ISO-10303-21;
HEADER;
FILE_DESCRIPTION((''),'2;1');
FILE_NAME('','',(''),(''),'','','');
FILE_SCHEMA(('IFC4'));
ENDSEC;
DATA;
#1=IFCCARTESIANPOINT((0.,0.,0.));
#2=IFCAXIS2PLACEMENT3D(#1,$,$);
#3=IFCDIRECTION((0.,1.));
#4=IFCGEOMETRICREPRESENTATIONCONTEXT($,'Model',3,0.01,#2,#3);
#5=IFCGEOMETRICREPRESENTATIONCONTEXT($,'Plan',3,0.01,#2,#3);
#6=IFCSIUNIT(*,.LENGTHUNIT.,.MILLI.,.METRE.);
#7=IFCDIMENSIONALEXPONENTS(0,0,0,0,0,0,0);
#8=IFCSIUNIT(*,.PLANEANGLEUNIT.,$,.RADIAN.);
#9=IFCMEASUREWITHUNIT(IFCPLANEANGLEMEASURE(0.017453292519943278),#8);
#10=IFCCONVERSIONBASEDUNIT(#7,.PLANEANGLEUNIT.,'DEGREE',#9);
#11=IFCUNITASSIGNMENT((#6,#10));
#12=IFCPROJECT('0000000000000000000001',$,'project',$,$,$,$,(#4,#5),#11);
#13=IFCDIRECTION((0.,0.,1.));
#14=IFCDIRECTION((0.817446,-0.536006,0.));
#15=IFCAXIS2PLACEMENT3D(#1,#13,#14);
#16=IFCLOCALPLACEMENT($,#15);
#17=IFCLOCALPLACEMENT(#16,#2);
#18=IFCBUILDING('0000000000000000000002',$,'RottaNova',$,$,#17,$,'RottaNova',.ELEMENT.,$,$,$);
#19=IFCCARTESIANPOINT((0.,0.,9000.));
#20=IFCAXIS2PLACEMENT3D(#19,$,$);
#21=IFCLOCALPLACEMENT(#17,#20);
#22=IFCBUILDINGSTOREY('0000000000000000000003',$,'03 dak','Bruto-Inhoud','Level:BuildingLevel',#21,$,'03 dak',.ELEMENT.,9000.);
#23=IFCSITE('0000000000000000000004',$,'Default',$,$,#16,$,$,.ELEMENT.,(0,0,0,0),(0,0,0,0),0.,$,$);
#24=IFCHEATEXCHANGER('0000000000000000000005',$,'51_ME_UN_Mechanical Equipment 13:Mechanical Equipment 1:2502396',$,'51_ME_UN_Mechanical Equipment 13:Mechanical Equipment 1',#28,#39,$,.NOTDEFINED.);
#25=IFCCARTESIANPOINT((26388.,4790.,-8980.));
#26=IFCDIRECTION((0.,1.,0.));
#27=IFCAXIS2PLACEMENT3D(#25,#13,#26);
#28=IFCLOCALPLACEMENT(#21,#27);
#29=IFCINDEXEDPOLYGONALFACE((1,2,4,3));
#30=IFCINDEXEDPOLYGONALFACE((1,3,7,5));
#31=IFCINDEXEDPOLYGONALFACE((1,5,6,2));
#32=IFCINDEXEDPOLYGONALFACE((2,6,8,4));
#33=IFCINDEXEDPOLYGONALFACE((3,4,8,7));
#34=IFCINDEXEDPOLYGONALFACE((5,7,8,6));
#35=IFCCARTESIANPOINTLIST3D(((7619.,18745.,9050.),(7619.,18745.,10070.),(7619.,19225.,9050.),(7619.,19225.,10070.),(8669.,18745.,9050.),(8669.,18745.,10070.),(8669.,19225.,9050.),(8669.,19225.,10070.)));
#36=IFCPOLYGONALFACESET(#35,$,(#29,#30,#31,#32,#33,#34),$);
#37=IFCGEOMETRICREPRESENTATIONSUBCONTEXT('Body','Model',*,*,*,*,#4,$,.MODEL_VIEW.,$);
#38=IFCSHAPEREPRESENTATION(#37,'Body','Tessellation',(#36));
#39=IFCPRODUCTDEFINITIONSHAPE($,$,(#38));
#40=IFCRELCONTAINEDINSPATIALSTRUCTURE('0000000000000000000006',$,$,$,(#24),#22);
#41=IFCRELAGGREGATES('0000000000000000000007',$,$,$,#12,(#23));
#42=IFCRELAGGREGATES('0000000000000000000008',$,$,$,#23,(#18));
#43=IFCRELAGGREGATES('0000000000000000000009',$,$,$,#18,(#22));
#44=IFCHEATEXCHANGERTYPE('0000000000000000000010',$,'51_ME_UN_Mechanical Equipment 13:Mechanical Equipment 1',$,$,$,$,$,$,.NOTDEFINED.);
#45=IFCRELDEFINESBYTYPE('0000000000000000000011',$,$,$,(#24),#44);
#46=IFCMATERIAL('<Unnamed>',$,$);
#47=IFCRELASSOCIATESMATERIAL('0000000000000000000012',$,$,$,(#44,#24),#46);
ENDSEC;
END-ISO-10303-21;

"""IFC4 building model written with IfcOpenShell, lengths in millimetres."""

from ifc_helpers import new_model, entity, si_unit, converted_unit, direction, frame, origin, place, context, subcontext, project, spatial, indexed_curve, outline, extrude, source, transform, mapped, material, type_object, type_shapes, element, save


model = new_model("IFC4")

# Units and contexts
model_context = context("Model", 3, precision=0.01, world=origin(), true_north=direction((0.0, 1.0)))
plan_context = context("Plan", 3, precision=0.01, world=origin(), true_north=direction((0.0, 1.0)))
body_context = subcontext(model_context, "Body", "Model", "MODEL_VIEW")
ifc_project = project(units=[si_unit("LENGTHUNIT", "METRE", prefix="MILLI"), converted_unit("PLANEANGLEUNIT", "DEGREE", entity("IfcPlaneAngleMeasure", 0.017453292519943278), si_unit("PLANEANGLEUNIT", "RADIAN"), dimensions=[0, 0, 0, 0, 0, 0, 0])], contexts=[model_context, plan_context])

# Site, building, storey
site_placement = place(None, frame((0.0, 0.0, 0.0), z_axis=(0.0, 0.0, 1.0), x_axis=(0.817446, -0.536006, 0.0)))
site = spatial("IfcSite", under=ifc_project, at=site_placement, Name="Default", CompositionType="ELEMENT", RefLatitude=(0, 0, 0, 0), RefLongitude=(0, 0, 0, 0), RefElevation=0.0)
building_placement = place(site_placement, origin())
building = spatial("IfcBuilding", under=site, at=building_placement, Name="RottaNova", LongName="RottaNova", CompositionType="ELEMENT")
storey_placement = place(building_placement, frame((0.0, 0.0, 9000.0)))
storey = spatial("IfcBuildingStorey", under=building, at=storey_placement, Name="03 dak", Description="Bruto-Inhoud", ObjectType="Level:BuildingLevel", LongName="03 dak", CompositionType="ELEMENT", Elevation=9000.0)

# Heat exchanger
ifc_material_1 = material(Name="<Unnamed>")
heat_exchanger_type_1 = type_object("IfcHeatExchangerType", Name="51_ME_UN_Mechanical Equipment 13:Mechanical Equipment 1", PredefinedType="NOTDEFINED", material=ifc_material_1)
shared_shape_1 = source(origin(), body_context, "Body", "SweptSolid", [
    extrude(outline(indexed_curve([(-525.0, -240.0), (525.0, -240.0), (525.0, 240.0), (-525.0, 240.0), (-525.0, -240.0)], self_intersect=False)), frame((8144.0, 18985.0, 9050.0), z_axis=(0.0, 0.0, 1.0), x_axis=(-1.0, 0.0, 0.0)), (0.0, 0.0, 1.0), 1020.0),
])
type_shapes(heat_exchanger_type_1, [shared_shape_1])
heat_exchanger_1_placement = place(storey_placement, frame((26388.0, 4790.0, -8980.0), z_axis=(0.0, 0.0, 1.0), x_axis=(0.0, 1.0, 0.0)))
element("IfcHeatExchanger", 1, at=heat_exchanger_1_placement, inside=storey, type_object=heat_exchanger_type_1, material=ifc_material_1, Name="51_ME_UN_Mechanical Equipment 13:Mechanical Equipment 1:2502396", ObjectType="51_ME_UN_Mechanical Equipment 13:Mechanical Equipment 1", PredefinedType="NOTDEFINED", context=body_context, shape_type="MappedRepresentation", body=[
    mapped(shared_shape_1, transform((0.0, 0.0, 0.0), scale=1.0)),
])

save(model, "model.ifc")
